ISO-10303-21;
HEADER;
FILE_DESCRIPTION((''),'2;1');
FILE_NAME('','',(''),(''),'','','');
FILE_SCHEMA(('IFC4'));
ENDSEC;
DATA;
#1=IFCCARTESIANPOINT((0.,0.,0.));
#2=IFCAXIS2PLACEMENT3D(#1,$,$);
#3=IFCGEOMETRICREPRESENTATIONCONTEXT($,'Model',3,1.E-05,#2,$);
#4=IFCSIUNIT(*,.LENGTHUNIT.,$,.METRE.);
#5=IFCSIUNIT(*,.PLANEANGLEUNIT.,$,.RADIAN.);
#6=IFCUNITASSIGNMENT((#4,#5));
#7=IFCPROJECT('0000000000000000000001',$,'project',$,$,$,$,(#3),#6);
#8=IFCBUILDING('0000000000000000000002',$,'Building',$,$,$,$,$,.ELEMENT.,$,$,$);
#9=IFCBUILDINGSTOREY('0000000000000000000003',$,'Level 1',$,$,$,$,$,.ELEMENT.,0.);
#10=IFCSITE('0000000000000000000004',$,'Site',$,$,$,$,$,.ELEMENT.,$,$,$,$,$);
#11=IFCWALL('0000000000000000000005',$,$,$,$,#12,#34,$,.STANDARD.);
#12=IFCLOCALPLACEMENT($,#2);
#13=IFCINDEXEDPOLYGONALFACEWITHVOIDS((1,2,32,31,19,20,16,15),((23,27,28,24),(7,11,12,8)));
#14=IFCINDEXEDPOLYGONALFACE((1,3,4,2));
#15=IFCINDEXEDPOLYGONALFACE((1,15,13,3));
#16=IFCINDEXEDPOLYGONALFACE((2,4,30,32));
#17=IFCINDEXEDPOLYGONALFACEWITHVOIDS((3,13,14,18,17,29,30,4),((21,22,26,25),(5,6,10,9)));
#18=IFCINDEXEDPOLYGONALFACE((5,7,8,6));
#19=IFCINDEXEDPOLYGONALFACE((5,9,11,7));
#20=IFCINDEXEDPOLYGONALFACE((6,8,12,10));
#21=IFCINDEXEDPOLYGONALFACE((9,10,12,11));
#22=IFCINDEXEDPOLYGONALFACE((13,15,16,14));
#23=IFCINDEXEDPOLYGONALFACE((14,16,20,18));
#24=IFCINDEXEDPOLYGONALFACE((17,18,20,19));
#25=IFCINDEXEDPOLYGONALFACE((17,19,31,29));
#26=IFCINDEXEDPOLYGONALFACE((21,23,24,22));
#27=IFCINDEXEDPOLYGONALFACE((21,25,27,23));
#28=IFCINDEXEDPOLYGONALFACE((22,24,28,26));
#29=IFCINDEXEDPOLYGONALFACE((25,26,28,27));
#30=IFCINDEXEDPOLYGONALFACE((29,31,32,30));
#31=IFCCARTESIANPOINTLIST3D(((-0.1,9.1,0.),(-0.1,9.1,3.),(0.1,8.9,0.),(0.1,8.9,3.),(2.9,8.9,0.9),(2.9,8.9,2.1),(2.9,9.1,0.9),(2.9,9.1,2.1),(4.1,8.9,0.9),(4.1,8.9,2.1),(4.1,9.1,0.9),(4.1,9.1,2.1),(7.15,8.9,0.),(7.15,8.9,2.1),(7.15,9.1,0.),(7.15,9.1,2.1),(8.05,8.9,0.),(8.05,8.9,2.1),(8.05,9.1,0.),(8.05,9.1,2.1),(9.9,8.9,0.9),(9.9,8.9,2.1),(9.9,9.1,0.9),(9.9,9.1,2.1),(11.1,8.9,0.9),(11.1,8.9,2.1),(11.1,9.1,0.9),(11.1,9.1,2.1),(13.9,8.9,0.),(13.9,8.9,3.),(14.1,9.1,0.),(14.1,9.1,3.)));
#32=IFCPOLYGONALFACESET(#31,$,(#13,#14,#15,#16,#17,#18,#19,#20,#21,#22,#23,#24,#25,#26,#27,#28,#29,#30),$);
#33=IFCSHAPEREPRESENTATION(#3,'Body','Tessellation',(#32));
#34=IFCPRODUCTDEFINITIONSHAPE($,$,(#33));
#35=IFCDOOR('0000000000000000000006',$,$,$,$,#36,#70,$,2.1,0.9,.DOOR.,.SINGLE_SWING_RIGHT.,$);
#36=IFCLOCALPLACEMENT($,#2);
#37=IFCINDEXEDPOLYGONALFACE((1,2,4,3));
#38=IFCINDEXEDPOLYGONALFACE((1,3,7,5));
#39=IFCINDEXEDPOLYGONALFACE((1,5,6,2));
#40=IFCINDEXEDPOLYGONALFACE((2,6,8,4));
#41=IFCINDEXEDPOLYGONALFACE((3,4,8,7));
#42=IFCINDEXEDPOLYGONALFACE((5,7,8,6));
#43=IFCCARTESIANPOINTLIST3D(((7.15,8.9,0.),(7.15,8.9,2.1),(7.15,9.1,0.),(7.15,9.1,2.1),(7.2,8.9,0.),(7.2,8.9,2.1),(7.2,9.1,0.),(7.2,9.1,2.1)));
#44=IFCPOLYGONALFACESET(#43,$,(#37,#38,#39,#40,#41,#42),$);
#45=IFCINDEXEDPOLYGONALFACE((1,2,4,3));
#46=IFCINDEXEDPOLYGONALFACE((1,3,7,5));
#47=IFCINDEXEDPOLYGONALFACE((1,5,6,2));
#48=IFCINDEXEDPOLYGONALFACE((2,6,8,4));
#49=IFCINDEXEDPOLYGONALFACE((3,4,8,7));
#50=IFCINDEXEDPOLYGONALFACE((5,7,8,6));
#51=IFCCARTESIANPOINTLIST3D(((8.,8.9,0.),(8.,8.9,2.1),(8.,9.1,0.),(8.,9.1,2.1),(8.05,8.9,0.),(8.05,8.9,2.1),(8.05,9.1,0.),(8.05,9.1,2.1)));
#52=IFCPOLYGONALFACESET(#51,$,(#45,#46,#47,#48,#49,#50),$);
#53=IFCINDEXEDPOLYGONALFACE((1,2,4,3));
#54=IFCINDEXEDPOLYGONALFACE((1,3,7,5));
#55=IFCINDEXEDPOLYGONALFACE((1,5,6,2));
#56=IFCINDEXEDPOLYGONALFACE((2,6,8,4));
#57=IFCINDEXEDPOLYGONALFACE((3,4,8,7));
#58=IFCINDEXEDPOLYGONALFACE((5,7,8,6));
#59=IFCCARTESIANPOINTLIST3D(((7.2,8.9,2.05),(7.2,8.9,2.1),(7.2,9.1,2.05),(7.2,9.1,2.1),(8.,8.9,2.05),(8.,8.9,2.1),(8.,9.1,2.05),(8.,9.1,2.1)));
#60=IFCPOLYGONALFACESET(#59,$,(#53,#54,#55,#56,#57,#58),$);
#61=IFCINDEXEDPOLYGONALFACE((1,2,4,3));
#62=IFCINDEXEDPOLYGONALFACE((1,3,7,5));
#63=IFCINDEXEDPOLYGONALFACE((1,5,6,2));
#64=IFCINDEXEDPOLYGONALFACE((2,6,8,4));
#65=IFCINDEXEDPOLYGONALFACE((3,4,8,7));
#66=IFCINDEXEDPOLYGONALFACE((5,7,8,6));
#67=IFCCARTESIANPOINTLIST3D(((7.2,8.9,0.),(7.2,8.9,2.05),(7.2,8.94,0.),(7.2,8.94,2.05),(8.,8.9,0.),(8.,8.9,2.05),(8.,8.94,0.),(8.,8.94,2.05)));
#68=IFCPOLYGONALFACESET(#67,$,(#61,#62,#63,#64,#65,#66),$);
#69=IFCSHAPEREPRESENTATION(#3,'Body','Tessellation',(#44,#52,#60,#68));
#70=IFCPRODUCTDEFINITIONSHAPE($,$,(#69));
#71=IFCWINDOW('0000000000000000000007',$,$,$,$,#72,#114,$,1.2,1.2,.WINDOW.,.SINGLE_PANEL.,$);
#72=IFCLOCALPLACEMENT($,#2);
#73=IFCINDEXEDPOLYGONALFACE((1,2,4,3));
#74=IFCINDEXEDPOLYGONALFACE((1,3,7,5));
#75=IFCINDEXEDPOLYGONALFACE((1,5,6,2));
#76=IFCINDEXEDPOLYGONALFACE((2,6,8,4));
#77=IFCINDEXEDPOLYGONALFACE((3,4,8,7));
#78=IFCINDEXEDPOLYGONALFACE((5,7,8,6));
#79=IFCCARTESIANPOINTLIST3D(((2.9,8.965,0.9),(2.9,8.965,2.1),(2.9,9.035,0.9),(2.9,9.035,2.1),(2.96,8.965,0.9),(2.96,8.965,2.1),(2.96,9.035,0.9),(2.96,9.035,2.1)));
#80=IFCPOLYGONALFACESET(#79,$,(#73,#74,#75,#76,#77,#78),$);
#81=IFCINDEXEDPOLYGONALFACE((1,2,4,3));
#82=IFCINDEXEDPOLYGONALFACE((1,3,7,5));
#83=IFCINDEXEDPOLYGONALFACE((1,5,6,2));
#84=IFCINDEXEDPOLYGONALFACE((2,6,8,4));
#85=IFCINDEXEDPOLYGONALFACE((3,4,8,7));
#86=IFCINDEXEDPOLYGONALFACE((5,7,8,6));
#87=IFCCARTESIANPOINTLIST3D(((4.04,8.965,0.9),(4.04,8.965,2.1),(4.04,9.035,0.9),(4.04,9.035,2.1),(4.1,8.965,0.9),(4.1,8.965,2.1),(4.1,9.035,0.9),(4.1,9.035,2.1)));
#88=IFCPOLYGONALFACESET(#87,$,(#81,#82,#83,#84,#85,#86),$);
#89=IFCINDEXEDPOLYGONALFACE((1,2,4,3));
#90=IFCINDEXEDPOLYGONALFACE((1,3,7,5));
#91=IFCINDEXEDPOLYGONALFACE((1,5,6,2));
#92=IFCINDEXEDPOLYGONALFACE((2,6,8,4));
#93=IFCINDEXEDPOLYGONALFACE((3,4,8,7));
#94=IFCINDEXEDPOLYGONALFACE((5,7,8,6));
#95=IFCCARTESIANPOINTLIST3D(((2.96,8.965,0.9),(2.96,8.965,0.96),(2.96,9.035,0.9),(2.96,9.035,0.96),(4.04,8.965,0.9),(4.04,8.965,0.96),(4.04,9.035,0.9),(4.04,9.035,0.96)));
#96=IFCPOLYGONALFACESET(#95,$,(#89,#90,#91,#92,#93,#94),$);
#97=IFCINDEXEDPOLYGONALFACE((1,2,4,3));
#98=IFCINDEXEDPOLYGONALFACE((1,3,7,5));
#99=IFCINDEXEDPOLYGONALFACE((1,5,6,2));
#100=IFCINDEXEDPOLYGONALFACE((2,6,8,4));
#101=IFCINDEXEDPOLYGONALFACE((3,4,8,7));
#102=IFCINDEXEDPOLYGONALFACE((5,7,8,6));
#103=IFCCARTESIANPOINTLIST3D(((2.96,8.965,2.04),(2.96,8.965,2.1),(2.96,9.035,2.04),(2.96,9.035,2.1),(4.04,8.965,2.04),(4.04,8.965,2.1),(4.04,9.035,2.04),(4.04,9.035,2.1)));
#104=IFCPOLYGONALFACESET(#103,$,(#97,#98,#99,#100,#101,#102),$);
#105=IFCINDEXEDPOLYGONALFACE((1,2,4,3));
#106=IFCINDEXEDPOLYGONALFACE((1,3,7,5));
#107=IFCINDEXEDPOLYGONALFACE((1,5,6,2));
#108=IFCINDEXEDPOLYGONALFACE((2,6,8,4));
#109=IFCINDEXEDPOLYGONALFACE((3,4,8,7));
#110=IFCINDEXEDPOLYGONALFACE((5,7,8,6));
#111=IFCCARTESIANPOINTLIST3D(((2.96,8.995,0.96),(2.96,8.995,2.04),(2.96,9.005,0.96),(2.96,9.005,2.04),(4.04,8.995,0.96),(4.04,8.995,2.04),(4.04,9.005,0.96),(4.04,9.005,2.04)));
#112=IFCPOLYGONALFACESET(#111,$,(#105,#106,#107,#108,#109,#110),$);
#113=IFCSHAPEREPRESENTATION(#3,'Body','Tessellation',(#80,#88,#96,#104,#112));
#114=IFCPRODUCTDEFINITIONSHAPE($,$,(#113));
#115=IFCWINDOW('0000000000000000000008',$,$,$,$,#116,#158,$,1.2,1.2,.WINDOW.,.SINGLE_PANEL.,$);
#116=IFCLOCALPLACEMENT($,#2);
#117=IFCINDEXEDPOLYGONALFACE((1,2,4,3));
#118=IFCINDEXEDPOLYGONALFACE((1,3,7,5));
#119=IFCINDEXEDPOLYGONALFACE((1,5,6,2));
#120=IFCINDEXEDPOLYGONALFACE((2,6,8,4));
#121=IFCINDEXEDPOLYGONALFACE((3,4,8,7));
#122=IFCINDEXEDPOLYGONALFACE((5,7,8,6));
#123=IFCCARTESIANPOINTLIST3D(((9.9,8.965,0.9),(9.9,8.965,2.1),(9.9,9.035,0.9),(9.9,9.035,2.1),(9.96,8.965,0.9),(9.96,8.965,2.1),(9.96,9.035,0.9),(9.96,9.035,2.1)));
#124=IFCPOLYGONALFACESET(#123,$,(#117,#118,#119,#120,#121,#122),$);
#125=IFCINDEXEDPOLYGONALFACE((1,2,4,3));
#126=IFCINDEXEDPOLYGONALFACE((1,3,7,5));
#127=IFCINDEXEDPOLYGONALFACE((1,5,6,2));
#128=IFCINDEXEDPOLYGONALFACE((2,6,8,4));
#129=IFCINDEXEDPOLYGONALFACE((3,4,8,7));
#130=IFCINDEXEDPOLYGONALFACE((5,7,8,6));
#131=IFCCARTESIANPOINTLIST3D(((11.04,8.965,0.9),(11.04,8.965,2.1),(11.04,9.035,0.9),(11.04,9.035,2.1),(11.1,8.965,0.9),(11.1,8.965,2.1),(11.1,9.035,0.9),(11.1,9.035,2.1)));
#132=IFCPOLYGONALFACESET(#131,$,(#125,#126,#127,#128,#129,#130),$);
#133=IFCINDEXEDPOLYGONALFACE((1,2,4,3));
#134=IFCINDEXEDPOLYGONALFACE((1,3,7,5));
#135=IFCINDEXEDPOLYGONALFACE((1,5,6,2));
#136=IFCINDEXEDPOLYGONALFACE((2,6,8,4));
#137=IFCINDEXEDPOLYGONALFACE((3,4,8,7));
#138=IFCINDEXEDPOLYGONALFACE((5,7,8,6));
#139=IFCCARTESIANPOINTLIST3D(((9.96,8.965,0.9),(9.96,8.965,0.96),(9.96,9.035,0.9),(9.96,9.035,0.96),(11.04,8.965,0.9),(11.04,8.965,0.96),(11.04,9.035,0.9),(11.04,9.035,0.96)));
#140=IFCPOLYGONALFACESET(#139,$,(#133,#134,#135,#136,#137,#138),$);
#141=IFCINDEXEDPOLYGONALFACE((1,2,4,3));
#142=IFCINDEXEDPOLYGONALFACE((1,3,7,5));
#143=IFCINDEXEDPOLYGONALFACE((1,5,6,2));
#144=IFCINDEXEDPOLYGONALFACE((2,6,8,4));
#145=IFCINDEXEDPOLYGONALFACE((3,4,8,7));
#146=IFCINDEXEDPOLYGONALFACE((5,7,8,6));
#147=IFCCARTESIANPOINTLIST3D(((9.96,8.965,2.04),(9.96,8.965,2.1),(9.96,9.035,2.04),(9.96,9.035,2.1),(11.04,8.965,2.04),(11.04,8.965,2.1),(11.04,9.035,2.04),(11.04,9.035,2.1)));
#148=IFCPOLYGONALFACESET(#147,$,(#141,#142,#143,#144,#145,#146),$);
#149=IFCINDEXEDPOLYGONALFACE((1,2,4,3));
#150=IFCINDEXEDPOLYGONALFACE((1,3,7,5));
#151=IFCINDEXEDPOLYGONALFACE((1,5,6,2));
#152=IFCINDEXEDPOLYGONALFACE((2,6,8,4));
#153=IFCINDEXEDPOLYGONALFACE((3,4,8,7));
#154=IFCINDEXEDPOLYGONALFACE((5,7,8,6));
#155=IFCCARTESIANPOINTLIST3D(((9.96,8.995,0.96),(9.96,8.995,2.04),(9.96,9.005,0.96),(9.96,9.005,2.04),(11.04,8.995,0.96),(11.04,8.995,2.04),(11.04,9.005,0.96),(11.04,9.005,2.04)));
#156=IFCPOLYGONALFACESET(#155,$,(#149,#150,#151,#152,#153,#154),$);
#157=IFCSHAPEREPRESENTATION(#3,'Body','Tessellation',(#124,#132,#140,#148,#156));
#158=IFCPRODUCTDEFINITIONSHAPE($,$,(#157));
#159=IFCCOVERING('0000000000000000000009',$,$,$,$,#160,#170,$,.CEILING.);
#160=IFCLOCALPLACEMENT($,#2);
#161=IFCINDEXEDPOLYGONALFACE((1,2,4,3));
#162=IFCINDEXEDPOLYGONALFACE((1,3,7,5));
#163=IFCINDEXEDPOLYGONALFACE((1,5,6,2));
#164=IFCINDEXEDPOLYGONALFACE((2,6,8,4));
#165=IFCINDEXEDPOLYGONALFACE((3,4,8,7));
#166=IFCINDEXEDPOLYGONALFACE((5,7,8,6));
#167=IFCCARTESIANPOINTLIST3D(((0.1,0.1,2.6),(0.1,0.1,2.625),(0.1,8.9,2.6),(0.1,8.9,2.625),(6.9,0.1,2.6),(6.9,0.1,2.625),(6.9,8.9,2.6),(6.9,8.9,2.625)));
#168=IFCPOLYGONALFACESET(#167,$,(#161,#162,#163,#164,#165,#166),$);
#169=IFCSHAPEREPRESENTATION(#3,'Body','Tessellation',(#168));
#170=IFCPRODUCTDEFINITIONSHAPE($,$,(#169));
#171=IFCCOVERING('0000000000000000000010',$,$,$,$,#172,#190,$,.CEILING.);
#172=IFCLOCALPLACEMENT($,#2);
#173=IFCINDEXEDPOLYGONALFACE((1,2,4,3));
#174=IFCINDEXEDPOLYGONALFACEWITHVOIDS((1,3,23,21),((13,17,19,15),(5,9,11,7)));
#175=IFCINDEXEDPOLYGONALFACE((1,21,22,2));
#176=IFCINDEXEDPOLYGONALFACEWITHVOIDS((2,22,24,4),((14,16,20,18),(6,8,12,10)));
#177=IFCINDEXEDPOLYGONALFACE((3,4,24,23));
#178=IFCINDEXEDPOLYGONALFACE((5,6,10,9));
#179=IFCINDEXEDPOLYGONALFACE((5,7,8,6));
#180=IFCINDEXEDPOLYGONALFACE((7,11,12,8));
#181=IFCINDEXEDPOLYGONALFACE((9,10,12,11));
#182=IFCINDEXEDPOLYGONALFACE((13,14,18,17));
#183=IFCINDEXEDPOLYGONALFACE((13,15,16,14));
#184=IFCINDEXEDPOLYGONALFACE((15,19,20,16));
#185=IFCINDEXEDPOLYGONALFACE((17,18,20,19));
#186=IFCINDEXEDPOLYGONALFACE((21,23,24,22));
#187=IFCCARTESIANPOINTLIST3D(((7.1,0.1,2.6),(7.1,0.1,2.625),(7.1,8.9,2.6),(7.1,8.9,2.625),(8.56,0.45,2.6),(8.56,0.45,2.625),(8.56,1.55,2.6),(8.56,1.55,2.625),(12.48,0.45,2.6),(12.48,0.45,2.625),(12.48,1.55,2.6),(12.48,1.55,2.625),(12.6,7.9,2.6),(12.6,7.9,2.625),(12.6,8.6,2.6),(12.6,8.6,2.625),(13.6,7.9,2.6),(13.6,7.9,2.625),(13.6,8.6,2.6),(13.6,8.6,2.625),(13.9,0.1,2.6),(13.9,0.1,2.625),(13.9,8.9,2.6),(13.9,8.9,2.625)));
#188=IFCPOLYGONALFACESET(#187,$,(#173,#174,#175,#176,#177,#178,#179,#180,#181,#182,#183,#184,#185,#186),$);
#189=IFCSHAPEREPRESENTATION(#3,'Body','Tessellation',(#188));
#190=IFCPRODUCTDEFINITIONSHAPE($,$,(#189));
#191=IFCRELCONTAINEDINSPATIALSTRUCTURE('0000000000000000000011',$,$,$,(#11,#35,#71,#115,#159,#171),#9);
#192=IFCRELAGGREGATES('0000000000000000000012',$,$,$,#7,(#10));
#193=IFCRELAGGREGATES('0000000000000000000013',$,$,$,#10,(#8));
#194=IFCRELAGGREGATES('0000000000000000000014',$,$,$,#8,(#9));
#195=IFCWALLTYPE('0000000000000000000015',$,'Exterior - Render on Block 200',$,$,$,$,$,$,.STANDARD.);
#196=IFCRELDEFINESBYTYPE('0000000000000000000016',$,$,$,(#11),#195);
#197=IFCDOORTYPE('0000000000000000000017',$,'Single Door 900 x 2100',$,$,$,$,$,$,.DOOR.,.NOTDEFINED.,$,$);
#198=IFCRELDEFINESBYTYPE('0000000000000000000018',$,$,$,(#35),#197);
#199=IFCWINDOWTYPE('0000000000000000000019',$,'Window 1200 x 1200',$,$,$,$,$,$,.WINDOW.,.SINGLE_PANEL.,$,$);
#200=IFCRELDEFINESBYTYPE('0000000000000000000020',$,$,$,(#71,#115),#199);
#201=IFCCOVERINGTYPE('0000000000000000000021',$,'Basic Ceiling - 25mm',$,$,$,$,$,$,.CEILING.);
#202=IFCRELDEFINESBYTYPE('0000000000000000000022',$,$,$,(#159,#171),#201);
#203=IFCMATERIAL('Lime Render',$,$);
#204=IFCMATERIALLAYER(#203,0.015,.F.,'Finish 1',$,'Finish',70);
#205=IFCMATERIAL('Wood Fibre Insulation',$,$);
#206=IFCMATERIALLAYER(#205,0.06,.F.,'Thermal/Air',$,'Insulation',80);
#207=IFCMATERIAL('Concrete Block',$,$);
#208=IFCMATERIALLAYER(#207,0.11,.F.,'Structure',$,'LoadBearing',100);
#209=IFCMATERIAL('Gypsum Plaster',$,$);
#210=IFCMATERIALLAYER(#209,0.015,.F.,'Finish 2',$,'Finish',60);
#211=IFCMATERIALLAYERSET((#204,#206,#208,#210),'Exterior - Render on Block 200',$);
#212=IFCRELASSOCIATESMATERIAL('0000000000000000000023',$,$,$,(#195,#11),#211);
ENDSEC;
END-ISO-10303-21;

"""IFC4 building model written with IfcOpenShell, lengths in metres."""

from ifc_helpers import new_model, si_unit, frame, frame_2d, origin, origin_with_axes, origin_2d, place, context, project, spatial, polyline, rectangle, outline, extrude, material, layer, layer_set, layer_usage, type_object, element, fill, save


model = new_model("IFC4")

# Units and contexts
model_context = context("Model", 3, precision=1e-05, world=origin())
ifc_project = project(units=[si_unit("LENGTHUNIT", "METRE"), si_unit("PLANEANGLEUNIT", "RADIAN")], contexts=[model_context])

# Site, building, storey
site = spatial("IfcSite", under=ifc_project, Name="Site", CompositionType="ELEMENT")
building = spatial("IfcBuilding", under=site, Name="Building", CompositionType="ELEMENT")
storey = spatial("IfcBuildingStorey", under=building, Name="Level 1", CompositionType="ELEMENT", Elevation=0.0)

# Shared definitions
window_type_1 = type_object("IfcWindowType", Name="Window 1200 x 1200", PartitioningType="SINGLE_PANEL", PredefinedType="WINDOW")

# Wall, openings, door, windows
ifc_material_1 = material(Name="Lime Render")
ifc_layer_1 = layer(ifc_material_1, 0.015, ventilated=False, Name="Finish 1", Category="Finish", Priority=70)
ifc_material_2 = material(Name="Wood Fibre Insulation")
ifc_layer_2 = layer(ifc_material_2, 0.06, ventilated=False, Name="Thermal/Air", Category="Insulation", Priority=80)
ifc_material_3 = material(Name="Concrete Block")
ifc_layer_3 = layer(ifc_material_3, 0.11, ventilated=False, Name="Structure", Category="LoadBearing", Priority=100)
ifc_material_4 = material(Name="Gypsum Plaster")
ifc_layer_4 = layer(ifc_material_4, 0.015, ventilated=False, Name="Finish 2", Category="Finish", Priority=60)
ifc_layer_set = layer_set([ifc_layer_1, ifc_layer_2, ifc_layer_3, ifc_layer_4], Name="Exterior - Render on Block 200")
ifc_layer_usage = layer_usage(ifc_layer_set, "AXIS2", "POSITIVE", -0.1)
wall_type_1 = type_object("IfcWallType", Name="Exterior - Render on Block 200", PredefinedType="STANDARD", material=ifc_layer_set)
wall_1_placement = place(None, frame((0.0, 9.0, 0.0), z_axis=(0.0, 0.0, 1.0), x_axis=(1.0, 0.0, 0.0)))
wall_1 = element("IfcWall", 1, at=wall_1_placement, inside=storey, type_object=wall_type_1, material=ifc_layer_usage, PredefinedType="STANDARD", context=model_context, shape_type="SweptSolid", body=[
    extrude(outline(polyline([(0.1, -0.1), (13.9, -0.1), (14.1, 0.1), (-0.1, 0.1), (0.1, -0.1)])), origin(), (0.0, 0.0, 1.0), 3.0),
])
opening_1_placement = place(wall_1_placement, frame((3.5, 0.0, 0.9), z_axis=(0.0, 0.0, 1.0), x_axis=(1.0, 0.0, 0.0)))
opening_1 = element("IfcOpeningElement", 2, at=opening_1_placement, cuts=wall_1, PredefinedType="OPENING", context=model_context, shape_type="SweptSolid", body=[
    extrude(rectangle(XDim=1.2, YDim=0.202, at=origin_2d()), origin(), (0.0, 0.0, 1.0), 1.2),
])
opening_2_placement = place(wall_1_placement, frame((10.5, 0.0, 0.9), z_axis=(0.0, 0.0, 1.0), x_axis=(1.0, 0.0, 0.0)))
opening_2 = element("IfcOpeningElement", 3, at=opening_2_placement, cuts=wall_1, PredefinedType="OPENING", context=model_context, shape_type="SweptSolid", body=[
    extrude(rectangle(XDim=1.2, YDim=0.202, at=origin_2d()), origin(), (0.0, 0.0, 1.0), 1.2),
])
opening_3_placement = place(wall_1_placement, frame((7.6, 0.0, 0.0), z_axis=(0.0, 0.0, 1.0), x_axis=(1.0, 0.0, 0.0)))
opening_3 = element("IfcOpeningElement", 4, at=opening_3_placement, cuts=wall_1, PredefinedType="OPENING", context=model_context, shape_type="SweptSolid", body=[
    extrude(rectangle(XDim=0.9, YDim=0.202, at=origin_2d()), origin(), (0.0, 0.0, 1.0), 2.1),
])
door_type = type_object("IfcDoorType", Name="Single Door 900 x 2100", OperationType="NOTDEFINED", PredefinedType="DOOR")
door_1_placement = place(opening_3_placement, origin_with_axes())
door_1 = element("IfcDoor", 5, at=door_1_placement, inside=storey, type_object=door_type, OperationType="SINGLE_SWING_RIGHT", OverallHeight=2.1, OverallWidth=0.9, PredefinedType="DOOR", context=model_context, shape_type="SweptSolid", body=[
    extrude(rectangle(XDim=0.05, YDim=0.2, at=frame_2d((-0.425, 0.0))), origin(), (0.0, 0.0, 1.0), 2.1),
    extrude(rectangle(XDim=0.05, YDim=0.2, at=frame_2d((0.425, 0.0))), origin(), (0.0, 0.0, 1.0), 2.1),
    extrude(rectangle(XDim=0.8, YDim=0.2, at=origin_2d()), frame((0.0, 0.0, 2.05)), (0.0, 0.0, 1.0), 0.05),
    extrude(rectangle(XDim=0.8, YDim=0.04, at=frame_2d((0.0, -0.08))), origin(), (0.0, 0.0, 1.0), 2.05),
])
fill(opening_3, door_1)
window_1_placement = place(opening_1_placement, origin_with_axes())
window_1 = element("IfcWindow", 6, at=window_1_placement, inside=storey, type_object=window_type_1, OverallHeight=1.2, OverallWidth=1.2, PartitioningType="SINGLE_PANEL", PredefinedType="WINDOW", context=model_context, shape_type="SweptSolid", body=[
    extrude(rectangle(XDim=0.06, YDim=0.07, at=frame_2d((-0.57, 0.0))), origin(), (0.0, 0.0, 1.0), 1.2),
    extrude(rectangle(XDim=0.06, YDim=0.07, at=frame_2d((0.57, 0.0))), origin(), (0.0, 0.0, 1.0), 1.2),
    extrude(rectangle(XDim=1.08, YDim=0.07, at=origin_2d()), origin(), (0.0, 0.0, 1.0), 0.06),
    extrude(rectangle(XDim=1.08, YDim=0.07, at=origin_2d()), frame((0.0, 0.0, 1.14)), (0.0, 0.0, 1.0), 0.06),
    extrude(rectangle(XDim=1.08, YDim=0.01, at=origin_2d()), frame((0.0, 0.0, 0.06)), (0.0, 0.0, 1.0), 1.08),
])
fill(opening_1, window_1)
window_2_placement = place(opening_2_placement, origin_with_axes())
window_2 = element("IfcWindow", 7, at=window_2_placement, inside=storey, type_object=window_type_1, OverallHeight=1.2, OverallWidth=1.2, PartitioningType="SINGLE_PANEL", PredefinedType="WINDOW", context=model_context, shape_type="SweptSolid", body=[
    extrude(rectangle(XDim=0.06, YDim=0.07, at=frame_2d((-0.57, 0.0))), origin(), (0.0, 0.0, 1.0), 1.2),
    extrude(rectangle(XDim=0.06, YDim=0.07, at=frame_2d((0.57, 0.0))), origin(), (0.0, 0.0, 1.0), 1.2),
    extrude(rectangle(XDim=1.08, YDim=0.07, at=origin_2d()), origin(), (0.0, 0.0, 1.0), 0.06),
    extrude(rectangle(XDim=1.08, YDim=0.07, at=origin_2d()), frame((0.0, 0.0, 1.14)), (0.0, 0.0, 1.0), 0.06),
    extrude(rectangle(XDim=1.08, YDim=0.01, at=origin_2d()), frame((0.0, 0.0, 0.06)), (0.0, 0.0, 1.0), 1.08),
])
fill(opening_2, window_2)

# Covering
covering_type = type_object("IfcCoveringType", Name="Basic Ceiling - 25mm", PredefinedType="CEILING")
covering_1_placement = place(None, frame((0.0, 0.0, 2.625)))
element("IfcCovering", 8, at=covering_1_placement, inside=storey, type_object=covering_type, PredefinedType="CEILING", context=model_context, shape_type="SweptSolid", body=[
    extrude(outline(polyline([(0.1, 0.1), (6.9, 0.1), (6.9, 8.9), (0.1, 8.9), (0.1, 0.1)])), origin(), (0.0, 0.0, -1.0), 0.025),
])

# Covering, openings
covering_2_placement = place(None, frame((0.0, 0.0, 2.625)))
covering_2 = element("IfcCovering", 9, at=covering_2_placement, inside=storey, type_object=covering_type, PredefinedType="CEILING", context=model_context, shape_type="SweptSolid", body=[
    extrude(outline(polyline([(7.1, 0.1), (13.9, 0.1), (13.9, 8.9), (7.1, 8.9), (7.1, 0.1)])), origin(), (0.0, 0.0, -1.0), 0.025),
])
opening_4_placement = place(None, frame((0.0, 0.0, 2.626)))
element("IfcOpeningElement", 10, at=opening_4_placement, cuts=covering_2, PredefinedType="OPENING", context=model_context, shape_type="SweptSolid", body=[
    extrude(outline(polyline([(8.56, 1.55), (8.56, 0.45), (12.48, 0.45), (12.48, 1.55), (8.56, 1.55)])), origin(), (0.0, 0.0, -1.0), 0.027),
])
opening_5_placement = place(None, frame((0.0, 0.0, 2.626)))
element("IfcOpeningElement", 11, at=opening_5_placement, cuts=covering_2, PredefinedType="OPENING", context=model_context, shape_type="SweptSolid", body=[
    extrude(outline(polyline([(12.6, 7.9), (13.6, 7.9), (13.6, 8.6), (12.6, 8.6), (12.6, 7.9)])), origin(), (0.0, 0.0, -1.0), 0.027),
])

save(model, "model.ifc")
